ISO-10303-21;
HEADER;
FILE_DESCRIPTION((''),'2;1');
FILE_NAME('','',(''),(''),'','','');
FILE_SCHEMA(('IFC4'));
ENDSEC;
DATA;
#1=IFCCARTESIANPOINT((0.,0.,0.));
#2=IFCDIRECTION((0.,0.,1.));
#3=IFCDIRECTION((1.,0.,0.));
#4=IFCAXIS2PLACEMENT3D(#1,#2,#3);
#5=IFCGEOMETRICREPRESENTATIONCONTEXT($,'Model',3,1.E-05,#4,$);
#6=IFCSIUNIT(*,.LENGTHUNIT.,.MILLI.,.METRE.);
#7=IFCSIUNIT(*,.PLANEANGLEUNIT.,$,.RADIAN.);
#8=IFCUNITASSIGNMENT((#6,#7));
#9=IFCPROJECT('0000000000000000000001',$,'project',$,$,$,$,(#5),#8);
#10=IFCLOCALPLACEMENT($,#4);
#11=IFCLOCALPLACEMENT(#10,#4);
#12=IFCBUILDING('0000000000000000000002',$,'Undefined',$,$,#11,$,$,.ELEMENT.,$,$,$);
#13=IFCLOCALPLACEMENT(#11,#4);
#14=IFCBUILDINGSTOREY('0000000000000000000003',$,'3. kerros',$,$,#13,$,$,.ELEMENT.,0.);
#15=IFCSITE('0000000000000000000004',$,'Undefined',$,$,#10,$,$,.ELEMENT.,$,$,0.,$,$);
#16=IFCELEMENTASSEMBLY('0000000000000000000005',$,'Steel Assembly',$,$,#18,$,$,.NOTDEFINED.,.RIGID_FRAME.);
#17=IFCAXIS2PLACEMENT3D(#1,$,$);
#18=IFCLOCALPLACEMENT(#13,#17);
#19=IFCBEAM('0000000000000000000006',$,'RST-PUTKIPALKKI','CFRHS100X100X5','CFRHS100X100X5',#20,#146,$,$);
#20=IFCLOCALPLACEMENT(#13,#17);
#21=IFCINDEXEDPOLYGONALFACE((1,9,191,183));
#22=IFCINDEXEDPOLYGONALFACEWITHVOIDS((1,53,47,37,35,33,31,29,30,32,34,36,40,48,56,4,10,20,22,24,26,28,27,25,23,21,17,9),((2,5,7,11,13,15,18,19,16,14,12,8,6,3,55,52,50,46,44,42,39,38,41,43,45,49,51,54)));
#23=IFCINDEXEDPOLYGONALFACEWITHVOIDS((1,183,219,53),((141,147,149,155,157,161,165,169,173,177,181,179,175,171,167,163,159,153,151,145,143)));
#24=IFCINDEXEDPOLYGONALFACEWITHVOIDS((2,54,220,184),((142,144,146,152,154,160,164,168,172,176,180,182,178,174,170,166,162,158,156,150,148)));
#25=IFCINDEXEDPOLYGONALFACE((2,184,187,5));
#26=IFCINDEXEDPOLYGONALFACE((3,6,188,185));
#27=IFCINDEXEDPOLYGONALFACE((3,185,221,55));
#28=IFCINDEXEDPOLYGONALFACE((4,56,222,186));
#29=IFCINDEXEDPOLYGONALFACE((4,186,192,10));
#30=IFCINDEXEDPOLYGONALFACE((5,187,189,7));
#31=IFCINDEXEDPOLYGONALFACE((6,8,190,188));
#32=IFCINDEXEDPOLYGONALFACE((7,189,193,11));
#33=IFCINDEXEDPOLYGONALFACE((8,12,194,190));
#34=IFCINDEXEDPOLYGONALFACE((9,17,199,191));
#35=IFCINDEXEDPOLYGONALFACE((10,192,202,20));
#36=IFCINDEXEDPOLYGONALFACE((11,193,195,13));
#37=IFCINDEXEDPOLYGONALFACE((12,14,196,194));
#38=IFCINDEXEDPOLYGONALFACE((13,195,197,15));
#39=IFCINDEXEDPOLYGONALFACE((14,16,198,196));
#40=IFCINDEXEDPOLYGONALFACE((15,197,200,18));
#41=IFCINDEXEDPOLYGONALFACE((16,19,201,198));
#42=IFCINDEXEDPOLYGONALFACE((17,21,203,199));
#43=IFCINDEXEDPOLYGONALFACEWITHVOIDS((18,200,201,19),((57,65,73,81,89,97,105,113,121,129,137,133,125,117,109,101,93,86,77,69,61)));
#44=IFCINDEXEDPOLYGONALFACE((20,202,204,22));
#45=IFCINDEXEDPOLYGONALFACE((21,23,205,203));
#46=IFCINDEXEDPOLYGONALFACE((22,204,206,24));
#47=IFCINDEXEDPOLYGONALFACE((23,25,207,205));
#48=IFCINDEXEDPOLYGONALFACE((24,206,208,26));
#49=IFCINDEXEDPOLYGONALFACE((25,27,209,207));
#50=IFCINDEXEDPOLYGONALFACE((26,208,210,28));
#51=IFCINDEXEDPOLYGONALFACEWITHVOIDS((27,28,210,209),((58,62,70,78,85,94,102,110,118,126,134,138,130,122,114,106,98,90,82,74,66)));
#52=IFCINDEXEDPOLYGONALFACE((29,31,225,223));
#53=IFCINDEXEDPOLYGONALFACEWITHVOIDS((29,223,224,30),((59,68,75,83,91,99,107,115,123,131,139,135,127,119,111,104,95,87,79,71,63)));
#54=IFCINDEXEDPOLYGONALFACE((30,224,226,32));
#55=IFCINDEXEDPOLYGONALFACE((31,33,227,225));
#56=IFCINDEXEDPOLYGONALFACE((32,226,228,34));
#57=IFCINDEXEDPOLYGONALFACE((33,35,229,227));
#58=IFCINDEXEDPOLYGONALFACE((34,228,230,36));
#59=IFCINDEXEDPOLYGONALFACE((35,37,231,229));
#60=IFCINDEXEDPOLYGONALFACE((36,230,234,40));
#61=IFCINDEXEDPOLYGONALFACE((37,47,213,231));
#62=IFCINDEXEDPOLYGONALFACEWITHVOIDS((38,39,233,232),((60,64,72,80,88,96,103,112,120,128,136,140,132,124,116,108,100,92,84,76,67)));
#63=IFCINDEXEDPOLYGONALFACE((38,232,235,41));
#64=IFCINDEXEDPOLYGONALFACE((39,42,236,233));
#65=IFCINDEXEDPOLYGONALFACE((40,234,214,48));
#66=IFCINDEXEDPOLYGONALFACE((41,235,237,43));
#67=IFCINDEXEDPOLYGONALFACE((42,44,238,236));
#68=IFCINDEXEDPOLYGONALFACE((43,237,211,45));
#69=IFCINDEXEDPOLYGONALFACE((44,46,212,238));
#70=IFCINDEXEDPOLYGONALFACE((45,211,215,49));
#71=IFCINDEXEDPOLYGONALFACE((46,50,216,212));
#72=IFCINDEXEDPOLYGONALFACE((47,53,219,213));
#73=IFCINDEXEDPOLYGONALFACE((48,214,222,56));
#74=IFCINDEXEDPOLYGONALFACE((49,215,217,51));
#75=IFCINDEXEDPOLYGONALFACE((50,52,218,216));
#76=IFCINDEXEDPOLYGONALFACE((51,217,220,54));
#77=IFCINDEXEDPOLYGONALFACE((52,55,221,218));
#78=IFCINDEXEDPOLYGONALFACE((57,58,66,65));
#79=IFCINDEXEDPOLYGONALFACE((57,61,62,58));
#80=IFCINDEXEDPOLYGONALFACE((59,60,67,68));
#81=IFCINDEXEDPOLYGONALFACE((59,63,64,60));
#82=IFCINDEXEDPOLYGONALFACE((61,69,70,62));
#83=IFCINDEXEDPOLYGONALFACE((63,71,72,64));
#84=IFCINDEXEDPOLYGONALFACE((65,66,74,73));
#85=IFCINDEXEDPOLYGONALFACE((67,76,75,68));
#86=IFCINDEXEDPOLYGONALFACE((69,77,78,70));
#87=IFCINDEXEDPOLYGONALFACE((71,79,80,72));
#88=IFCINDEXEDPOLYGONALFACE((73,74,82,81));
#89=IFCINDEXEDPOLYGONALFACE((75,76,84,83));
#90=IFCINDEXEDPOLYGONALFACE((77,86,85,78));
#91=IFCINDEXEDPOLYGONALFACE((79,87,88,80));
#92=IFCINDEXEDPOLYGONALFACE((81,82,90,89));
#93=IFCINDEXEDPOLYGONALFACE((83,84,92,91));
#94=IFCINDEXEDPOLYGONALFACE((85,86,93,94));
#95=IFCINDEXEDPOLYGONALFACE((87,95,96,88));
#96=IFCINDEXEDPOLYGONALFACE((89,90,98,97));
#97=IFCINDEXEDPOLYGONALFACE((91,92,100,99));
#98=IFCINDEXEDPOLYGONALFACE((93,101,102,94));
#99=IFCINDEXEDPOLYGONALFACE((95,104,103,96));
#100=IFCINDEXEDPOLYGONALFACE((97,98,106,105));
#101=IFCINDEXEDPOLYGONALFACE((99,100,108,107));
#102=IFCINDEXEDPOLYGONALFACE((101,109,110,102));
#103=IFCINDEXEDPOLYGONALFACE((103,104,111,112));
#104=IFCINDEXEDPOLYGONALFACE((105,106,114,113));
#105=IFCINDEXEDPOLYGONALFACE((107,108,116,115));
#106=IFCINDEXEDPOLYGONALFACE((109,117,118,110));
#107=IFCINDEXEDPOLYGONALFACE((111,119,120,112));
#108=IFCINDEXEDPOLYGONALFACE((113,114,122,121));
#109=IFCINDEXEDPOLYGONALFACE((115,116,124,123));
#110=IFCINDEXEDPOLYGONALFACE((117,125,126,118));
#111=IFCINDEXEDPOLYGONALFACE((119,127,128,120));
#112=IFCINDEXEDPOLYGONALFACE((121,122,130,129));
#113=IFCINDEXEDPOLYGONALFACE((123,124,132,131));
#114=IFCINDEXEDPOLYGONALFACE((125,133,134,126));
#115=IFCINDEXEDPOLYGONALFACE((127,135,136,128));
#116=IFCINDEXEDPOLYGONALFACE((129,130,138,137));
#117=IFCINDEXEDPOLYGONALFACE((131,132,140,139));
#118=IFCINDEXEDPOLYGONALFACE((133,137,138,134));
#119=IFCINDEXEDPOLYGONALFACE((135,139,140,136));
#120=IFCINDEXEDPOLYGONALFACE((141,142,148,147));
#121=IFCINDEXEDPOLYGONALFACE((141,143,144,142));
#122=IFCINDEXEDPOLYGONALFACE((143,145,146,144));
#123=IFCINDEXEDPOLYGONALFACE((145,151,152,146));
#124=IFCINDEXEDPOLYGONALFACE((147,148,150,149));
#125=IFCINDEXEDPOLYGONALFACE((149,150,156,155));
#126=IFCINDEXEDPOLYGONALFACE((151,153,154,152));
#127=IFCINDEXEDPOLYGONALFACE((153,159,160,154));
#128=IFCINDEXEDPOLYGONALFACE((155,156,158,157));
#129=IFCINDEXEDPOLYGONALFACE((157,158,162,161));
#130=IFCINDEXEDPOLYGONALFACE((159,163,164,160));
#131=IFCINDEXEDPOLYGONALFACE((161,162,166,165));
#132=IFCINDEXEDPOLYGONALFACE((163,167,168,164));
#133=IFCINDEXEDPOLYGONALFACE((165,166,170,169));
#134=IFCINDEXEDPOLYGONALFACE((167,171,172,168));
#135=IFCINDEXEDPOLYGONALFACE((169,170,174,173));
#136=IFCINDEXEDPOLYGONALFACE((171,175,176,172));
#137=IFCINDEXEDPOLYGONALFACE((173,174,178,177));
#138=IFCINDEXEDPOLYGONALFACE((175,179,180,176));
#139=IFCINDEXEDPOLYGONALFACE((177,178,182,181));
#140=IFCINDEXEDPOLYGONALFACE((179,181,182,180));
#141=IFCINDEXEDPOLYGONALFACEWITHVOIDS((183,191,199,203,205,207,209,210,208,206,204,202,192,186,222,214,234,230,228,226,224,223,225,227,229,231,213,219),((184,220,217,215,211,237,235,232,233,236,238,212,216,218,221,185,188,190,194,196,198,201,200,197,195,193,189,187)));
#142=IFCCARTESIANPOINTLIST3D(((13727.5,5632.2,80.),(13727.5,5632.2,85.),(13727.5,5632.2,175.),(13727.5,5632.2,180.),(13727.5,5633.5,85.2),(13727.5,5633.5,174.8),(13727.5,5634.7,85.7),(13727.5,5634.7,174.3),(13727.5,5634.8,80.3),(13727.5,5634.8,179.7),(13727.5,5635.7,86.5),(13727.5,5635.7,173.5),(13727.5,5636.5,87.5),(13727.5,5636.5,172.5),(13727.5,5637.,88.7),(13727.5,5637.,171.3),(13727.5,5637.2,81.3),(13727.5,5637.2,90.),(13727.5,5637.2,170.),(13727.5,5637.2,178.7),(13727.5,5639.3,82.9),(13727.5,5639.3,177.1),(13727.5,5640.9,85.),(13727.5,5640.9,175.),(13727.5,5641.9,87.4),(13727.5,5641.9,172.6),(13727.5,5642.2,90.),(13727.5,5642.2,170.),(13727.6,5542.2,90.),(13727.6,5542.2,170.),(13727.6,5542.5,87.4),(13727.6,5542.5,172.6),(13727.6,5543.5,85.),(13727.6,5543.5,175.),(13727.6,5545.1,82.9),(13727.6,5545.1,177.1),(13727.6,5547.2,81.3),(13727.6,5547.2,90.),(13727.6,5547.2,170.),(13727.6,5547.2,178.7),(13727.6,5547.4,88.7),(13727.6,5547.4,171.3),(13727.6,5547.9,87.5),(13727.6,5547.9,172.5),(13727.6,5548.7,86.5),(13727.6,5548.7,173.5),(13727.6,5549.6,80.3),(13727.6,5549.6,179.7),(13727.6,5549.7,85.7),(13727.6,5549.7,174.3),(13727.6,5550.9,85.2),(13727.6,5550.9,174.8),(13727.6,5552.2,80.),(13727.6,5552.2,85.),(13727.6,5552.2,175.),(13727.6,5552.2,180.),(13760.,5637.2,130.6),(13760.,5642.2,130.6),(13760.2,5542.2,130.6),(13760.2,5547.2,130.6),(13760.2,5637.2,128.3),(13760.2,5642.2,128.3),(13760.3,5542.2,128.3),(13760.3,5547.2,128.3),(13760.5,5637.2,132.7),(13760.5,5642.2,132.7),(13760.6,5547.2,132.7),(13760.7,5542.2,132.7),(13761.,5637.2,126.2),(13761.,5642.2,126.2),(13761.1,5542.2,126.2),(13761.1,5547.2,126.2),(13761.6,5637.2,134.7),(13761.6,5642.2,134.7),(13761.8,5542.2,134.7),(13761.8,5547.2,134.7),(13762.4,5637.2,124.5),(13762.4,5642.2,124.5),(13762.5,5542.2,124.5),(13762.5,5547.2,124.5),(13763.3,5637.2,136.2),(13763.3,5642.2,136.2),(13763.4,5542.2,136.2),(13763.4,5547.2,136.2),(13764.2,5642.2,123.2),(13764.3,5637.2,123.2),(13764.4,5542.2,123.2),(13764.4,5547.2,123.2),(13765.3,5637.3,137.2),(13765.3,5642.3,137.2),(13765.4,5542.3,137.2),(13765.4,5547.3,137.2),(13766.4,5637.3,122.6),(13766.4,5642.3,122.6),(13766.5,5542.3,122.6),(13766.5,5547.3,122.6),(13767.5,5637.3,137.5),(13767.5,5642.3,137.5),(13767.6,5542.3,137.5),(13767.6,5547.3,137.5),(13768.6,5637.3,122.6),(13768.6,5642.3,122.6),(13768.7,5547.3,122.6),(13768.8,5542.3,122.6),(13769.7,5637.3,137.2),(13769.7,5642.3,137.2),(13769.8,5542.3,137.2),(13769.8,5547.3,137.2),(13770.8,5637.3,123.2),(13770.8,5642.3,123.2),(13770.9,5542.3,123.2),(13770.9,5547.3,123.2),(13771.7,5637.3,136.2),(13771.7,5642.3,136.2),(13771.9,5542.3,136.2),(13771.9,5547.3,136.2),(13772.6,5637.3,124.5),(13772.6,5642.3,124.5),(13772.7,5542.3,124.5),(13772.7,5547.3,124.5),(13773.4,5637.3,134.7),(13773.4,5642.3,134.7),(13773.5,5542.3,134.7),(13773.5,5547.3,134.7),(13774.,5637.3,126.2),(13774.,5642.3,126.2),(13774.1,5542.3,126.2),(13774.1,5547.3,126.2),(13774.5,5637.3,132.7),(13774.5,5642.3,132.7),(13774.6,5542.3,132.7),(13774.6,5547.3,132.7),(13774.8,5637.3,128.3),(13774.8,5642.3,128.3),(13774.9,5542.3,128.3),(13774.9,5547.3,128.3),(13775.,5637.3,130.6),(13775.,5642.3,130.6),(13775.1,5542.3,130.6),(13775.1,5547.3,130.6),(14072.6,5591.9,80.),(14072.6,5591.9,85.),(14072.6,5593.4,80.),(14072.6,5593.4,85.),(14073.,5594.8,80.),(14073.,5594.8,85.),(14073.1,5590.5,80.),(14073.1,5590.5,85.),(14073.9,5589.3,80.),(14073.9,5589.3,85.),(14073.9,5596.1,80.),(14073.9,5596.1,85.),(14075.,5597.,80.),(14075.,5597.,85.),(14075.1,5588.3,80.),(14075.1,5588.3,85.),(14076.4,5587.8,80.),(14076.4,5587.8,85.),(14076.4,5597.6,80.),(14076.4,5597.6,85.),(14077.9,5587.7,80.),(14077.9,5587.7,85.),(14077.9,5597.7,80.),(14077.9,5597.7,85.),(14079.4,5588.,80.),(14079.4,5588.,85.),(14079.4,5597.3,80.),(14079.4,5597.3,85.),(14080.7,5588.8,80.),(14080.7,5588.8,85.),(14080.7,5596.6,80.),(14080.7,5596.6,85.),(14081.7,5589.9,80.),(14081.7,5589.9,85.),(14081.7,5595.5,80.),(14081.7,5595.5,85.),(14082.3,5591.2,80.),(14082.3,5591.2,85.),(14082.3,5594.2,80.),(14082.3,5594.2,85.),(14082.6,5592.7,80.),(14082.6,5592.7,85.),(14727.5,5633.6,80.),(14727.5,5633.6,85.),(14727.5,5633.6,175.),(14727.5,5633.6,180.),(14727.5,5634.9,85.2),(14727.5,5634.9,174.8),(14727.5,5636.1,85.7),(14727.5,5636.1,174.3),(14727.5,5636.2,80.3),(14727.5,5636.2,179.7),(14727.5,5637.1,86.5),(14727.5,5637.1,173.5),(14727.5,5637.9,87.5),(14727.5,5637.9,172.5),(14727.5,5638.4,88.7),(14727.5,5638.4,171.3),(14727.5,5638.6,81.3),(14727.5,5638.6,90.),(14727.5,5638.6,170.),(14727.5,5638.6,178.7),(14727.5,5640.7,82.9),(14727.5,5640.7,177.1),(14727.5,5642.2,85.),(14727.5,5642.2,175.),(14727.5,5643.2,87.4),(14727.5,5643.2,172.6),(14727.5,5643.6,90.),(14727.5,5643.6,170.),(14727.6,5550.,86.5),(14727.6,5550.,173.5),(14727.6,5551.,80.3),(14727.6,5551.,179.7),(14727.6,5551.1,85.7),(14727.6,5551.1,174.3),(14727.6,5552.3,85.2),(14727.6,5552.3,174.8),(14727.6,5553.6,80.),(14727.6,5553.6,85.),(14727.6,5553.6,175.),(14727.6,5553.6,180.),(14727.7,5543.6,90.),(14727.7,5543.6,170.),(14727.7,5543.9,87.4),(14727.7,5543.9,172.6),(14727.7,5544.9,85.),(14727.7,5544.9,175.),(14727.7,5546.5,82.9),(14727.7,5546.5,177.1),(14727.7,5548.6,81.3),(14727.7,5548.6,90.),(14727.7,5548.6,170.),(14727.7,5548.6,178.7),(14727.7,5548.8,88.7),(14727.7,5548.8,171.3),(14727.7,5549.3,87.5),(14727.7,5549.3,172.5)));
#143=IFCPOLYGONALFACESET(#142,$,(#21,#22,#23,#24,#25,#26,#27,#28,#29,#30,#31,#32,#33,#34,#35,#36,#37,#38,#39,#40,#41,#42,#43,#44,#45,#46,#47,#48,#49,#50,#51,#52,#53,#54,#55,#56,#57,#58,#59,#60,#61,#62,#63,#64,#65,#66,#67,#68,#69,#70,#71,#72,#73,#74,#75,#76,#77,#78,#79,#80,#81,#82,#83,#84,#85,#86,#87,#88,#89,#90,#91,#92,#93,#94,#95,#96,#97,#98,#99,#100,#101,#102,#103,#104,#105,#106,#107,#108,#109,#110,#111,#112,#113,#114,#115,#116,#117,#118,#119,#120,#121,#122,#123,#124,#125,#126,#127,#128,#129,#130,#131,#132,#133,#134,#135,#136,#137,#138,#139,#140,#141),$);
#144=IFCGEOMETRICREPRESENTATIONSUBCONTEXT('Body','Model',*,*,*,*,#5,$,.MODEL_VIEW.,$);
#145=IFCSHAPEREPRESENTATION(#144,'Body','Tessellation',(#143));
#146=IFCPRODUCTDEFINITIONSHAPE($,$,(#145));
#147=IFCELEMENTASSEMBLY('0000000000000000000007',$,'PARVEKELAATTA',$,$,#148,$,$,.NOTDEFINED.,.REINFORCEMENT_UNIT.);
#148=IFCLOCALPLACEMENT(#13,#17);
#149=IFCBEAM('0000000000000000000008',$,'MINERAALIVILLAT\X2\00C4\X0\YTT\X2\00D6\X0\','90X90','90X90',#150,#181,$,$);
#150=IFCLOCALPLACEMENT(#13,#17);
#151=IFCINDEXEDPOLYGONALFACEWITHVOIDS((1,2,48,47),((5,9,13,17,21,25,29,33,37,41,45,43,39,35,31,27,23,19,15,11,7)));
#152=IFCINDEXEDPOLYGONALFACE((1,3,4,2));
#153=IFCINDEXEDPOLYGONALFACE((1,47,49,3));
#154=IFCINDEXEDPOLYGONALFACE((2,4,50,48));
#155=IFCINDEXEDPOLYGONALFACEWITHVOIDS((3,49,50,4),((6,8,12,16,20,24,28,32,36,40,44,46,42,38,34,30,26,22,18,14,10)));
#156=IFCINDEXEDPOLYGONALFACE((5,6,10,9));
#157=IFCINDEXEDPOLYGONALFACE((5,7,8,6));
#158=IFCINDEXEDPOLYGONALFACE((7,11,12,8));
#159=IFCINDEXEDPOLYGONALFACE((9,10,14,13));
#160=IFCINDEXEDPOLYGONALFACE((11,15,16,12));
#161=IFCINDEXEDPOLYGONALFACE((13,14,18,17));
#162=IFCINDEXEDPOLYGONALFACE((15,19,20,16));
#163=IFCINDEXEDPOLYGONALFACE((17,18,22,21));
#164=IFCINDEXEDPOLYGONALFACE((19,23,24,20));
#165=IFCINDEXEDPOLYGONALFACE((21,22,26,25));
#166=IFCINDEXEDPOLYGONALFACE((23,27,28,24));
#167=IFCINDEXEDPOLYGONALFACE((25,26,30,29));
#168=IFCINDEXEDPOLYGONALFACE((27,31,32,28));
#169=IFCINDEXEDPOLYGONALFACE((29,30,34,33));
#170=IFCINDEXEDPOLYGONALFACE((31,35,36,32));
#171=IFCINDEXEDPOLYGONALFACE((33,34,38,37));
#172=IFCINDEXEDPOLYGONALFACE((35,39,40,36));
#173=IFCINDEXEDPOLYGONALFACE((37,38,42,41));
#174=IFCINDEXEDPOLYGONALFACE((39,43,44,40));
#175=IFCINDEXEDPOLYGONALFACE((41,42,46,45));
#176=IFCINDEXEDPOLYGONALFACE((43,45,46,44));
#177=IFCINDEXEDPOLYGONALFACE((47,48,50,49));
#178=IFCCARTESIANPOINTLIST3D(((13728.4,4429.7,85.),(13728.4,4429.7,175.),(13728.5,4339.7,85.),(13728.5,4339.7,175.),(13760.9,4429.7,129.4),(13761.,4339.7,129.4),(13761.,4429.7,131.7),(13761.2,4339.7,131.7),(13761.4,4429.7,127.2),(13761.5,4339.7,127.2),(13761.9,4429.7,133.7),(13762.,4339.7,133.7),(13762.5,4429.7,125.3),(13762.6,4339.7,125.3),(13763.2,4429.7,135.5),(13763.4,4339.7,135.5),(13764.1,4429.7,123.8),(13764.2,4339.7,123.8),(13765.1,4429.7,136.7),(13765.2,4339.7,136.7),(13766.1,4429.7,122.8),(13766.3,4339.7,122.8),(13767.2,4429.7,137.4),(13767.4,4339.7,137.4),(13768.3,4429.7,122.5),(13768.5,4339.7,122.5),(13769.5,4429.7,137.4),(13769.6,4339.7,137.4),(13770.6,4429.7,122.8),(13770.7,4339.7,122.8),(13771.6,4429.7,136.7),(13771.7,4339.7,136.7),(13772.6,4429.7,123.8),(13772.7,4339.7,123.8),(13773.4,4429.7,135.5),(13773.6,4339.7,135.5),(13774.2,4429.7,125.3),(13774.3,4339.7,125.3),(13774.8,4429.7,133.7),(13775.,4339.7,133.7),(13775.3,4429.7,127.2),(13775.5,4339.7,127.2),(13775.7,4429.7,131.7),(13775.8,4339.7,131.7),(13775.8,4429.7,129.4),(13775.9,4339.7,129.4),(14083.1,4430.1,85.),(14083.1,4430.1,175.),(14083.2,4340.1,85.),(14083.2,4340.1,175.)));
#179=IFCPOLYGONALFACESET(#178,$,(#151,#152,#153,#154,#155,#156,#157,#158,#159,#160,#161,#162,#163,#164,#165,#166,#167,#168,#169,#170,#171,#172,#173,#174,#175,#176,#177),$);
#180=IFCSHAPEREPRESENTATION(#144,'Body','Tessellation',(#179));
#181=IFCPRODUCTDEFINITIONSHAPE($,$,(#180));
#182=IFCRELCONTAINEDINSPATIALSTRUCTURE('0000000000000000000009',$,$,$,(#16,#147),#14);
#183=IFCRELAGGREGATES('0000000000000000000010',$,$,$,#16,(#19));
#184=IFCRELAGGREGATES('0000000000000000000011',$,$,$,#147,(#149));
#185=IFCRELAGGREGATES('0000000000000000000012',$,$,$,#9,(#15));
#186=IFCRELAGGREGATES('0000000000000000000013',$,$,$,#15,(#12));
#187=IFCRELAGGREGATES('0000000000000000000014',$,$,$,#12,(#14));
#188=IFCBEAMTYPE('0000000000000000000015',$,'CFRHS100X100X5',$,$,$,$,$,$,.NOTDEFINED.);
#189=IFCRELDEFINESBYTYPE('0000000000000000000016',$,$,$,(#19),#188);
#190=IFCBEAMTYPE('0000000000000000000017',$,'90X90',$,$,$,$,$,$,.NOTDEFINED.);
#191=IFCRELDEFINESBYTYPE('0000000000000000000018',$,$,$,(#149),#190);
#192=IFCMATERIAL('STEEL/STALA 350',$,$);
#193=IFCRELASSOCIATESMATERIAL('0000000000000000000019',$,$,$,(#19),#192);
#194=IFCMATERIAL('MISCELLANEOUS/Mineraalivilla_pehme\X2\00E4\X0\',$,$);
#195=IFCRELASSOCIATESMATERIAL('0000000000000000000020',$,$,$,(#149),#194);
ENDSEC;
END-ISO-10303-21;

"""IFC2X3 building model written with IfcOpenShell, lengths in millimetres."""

from ifc_helpers import new_model, si_unit, frame, origin_with_axes, origin_2d_with_axis, place, context, subcontext, project, spatial, rectangle, hollow_rectangle, circle, extrude, boolean, material, type_object, element, aggregate, save


model = new_model("IFC2X3")

# Units and contexts
model_context = context("Model", 3, precision=1e-05, world=origin_with_axes())
body_context = subcontext(model_context, "Body", "Model", "MODEL_VIEW")
ifc_project = project(units=[si_unit("LENGTHUNIT", "METRE", prefix="MILLI"), si_unit("PLANEANGLEUNIT", "RADIAN")], contexts=[model_context])

# Site, building, storey
site_placement = place(None, origin_with_axes())
site = spatial("IfcSite", under=ifc_project, at=site_placement, Name="Undefined", CompositionType="ELEMENT", RefElevation=0.0)
building_placement = place(site_placement, origin_with_axes())
building = spatial("IfcBuilding", under=site, at=building_placement, Name="Undefined", CompositionType="ELEMENT")
storey_placement = place(building_placement, origin_with_axes())
storey = spatial("IfcBuildingStorey", under=building, at=storey_placement, Name="3. kerros", CompositionType="ELEMENT", Elevation=0.0)

# Element assembly, beam
ifc_material_1 = material(Name="STEEL/STALA 350")
beam_type_1 = type_object("IfcBeamType", Name="CFRHS100X100X5", PredefinedType="NOTDEFINED")
assembly_1_placement = place(storey_placement, origin_with_axes())
assembly_1 = element("IfcElementAssembly", 1, at=assembly_1_placement, inside=storey, Name="Steel Assembly", AssemblyPlace="NOTDEFINED", PredefinedType="RIGID_FRAME")
beam_1_placement = place(assembly_1_placement, frame((13727.6, 5592.2, 130.0), z_axis=(0.0, 0.0, 1.0), x_axis=(0.999999, 0.001383, 0.0)))
beam_1 = element("IfcBeam", 2, at=beam_1_placement, type_object=beam_type_1, material=ifc_material_1, Name="RST-PUTKIPALKKI", Description="CFRHS100X100X5", ObjectType="CFRHS100X100X5", context=body_context, shape_type="CSG", body=[
    boolean("DIFFERENCE", boolean("DIFFERENCE", extrude(hollow_rectangle(XDim=100.0, YDim=100.0, WallThickness=5.0, InnerFilletRadius=5.0, OuterFilletRadius=10.0, at=origin_2d_with_axis()), frame((1000.0, 0.0, 0.0), z_axis=(-1.0, 0.0, 0.0), x_axis=(0.0, -1.0, 0.0)), (0.0, 0.0, 1.0), 1000.0), extrude(circle(Radius=7.5, at=origin_2d_with_axis()), frame((40.0, -69.8, 0.0), z_axis=(0.000031, 1.0, 0.0), x_axis=(0.0, 0.0, 1.0)), (0.0, 0.0, 1.0), 140.0)), extrude(circle(Radius=5.0, at=origin_2d_with_axis()), frame((350.0, 0.0, -40.0), z_axis=(0.0, 0.0, -1.0), x_axis=(1.0, -0.000035, 0.0)), (0.0, 0.0, 1.0), 30.0)),
])
aggregate(assembly_1, [beam_1])

# Element assembly, beam
assembly_2_placement = place(storey_placement, origin_with_axes())
assembly_2 = element("IfcElementAssembly", 3, at=assembly_2_placement, inside=storey, Name="PARVEKELAATTA", AssemblyPlace="NOTDEFINED", PredefinedType="REINFORCEMENT_UNIT")
ifc_material_2 = material(Name="MISCELLANEOUS/Mineraalivilla_pehmeä")
beam_type_2 = type_object("IfcBeamType", Name="90X90", PredefinedType="NOTDEFINED")
beam_2_placement = place(assembly_2_placement, frame((13728.4, 4384.7, 130.0), z_axis=(-0.001348, 0.999999, 0.0), x_axis=(0.999999, 0.001348, 0.0)))
beam_2 = element("IfcBeam", 4, at=beam_2_placement, type_object=beam_type_2, material=ifc_material_2, Name="MINERAALIVILLATÄYTTÖ", Description="90X90", ObjectType="90X90", context=body_context, shape_type="CSG", body=[
    boolean("DIFFERENCE", extrude(rectangle(XDim=90.0, YDim=90.0, at=origin_2d_with_axis()), frame((354.8, 0.0, 0.0), z_axis=(-1.0, 0.0, 0.0), x_axis=(0.0, -1.0, 0.0)), (0.0, 0.0, 1.0), 354.8), extrude(circle(Radius=7.5, at=origin_2d_with_axis()), frame((40.0, 0.0, 80.0), z_axis=(0.000032, 0.0, -1.0), x_axis=(0.0, 1.0, 0.0)), (0.0, 0.0, 1.0), 140.0)),
])
aggregate(assembly_2, [beam_2])

save(model, "model.ifc")
